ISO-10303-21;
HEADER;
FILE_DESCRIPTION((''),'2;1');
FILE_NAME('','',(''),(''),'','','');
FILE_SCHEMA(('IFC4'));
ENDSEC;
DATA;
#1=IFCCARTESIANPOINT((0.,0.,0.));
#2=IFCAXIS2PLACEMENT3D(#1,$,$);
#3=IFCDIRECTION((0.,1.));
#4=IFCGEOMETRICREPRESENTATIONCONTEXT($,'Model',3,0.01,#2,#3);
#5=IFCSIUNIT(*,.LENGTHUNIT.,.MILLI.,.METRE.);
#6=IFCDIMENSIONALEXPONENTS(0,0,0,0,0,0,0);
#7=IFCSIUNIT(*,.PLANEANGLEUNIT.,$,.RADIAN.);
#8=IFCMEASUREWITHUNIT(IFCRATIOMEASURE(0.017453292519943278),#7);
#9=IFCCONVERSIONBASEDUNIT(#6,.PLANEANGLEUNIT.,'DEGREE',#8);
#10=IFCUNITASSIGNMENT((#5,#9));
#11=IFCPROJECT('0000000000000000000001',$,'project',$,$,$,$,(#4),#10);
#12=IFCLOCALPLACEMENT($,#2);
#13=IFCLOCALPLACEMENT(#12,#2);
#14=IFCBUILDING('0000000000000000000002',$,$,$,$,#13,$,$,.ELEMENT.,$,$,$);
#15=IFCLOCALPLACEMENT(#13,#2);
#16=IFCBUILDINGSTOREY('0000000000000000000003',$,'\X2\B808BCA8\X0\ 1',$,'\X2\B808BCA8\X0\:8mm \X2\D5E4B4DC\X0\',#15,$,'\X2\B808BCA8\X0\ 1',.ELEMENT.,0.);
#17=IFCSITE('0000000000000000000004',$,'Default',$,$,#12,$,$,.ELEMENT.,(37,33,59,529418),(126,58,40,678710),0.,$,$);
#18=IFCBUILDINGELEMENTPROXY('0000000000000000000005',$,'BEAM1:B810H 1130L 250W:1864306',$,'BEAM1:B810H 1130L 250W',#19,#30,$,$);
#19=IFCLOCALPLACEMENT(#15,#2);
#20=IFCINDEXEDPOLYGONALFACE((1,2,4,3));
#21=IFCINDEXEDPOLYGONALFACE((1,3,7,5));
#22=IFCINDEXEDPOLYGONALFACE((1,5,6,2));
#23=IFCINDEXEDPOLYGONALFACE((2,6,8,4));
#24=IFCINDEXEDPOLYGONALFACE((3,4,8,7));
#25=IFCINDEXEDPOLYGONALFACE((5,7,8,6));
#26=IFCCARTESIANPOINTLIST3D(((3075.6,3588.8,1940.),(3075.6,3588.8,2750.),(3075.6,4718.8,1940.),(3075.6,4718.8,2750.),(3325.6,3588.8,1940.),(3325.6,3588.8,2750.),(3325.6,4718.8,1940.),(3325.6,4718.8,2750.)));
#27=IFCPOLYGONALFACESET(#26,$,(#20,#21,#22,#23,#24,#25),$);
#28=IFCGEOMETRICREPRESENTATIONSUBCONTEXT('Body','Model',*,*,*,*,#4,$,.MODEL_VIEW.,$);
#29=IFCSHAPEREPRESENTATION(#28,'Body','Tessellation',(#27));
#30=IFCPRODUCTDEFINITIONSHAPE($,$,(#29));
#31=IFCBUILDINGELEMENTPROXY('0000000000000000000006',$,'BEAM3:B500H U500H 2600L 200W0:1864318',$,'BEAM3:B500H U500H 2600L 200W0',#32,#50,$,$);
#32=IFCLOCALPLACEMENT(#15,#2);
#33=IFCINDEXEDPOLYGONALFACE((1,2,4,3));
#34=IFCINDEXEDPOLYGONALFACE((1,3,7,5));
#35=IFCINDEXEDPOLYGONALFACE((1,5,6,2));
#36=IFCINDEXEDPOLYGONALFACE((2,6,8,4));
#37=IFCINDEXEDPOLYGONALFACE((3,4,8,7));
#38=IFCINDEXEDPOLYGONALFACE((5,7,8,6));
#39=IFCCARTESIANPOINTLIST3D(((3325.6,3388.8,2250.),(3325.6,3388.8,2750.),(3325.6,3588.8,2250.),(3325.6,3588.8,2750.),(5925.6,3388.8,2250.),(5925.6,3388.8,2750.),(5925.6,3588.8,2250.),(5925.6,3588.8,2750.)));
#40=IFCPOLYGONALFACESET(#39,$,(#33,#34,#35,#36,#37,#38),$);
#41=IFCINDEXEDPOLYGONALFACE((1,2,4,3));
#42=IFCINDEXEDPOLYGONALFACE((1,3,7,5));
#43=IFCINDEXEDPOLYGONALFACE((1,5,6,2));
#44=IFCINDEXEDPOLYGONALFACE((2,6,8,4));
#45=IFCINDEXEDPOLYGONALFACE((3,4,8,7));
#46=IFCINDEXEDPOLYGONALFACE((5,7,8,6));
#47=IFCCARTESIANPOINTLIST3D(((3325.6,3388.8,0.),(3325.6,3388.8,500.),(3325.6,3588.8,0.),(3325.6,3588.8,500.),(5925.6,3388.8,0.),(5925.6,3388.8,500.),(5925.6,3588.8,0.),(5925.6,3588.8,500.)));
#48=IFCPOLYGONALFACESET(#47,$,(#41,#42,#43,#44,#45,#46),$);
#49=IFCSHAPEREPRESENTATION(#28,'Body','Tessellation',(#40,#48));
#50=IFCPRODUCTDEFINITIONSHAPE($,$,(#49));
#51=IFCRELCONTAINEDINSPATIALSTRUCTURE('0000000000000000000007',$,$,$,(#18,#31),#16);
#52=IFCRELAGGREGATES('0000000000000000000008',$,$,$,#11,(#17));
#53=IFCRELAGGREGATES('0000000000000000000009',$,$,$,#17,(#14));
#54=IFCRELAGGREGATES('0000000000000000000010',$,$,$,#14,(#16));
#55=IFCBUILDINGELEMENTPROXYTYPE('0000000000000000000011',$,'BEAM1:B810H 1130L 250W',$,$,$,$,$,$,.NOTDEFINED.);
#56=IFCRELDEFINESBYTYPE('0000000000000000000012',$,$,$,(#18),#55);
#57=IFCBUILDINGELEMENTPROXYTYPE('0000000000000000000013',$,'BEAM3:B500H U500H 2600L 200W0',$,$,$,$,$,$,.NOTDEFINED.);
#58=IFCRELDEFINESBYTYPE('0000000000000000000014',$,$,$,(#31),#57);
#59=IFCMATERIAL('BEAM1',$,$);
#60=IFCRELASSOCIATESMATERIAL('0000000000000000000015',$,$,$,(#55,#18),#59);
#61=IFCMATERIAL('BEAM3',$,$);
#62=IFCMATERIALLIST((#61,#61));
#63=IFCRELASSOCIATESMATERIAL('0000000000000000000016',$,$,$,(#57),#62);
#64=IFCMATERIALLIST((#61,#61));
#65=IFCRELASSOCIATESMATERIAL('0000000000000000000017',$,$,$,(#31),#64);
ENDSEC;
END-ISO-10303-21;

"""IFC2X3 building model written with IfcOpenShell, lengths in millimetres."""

from ifc_helpers import new_model, entity, si_unit, converted_unit, direction, frame, origin, origin_2d_with_axis, place, context, subcontext, project, spatial, rectangle, extrude, source, transform, mapped, material, material_list, type_object, type_shapes, element, save


model = new_model("IFC2X3")

# Units and contexts
model_context = context("Model", 3, precision=0.01, world=origin(), true_north=direction((0.0, 1.0)))
body_context = subcontext(model_context, "Body", "Model", "MODEL_VIEW")
ifc_project = project(units=[si_unit("LENGTHUNIT", "METRE", prefix="MILLI"), converted_unit("PLANEANGLEUNIT", "DEGREE", entity("IfcRatioMeasure", 0.017453292519943278), si_unit("PLANEANGLEUNIT", "RADIAN"), dimensions=[0, 0, 0, 0, 0, 0, 0])], contexts=[model_context])

# Site, building, storey
site_placement = place(None, origin())
site = spatial("IfcSite", under=ifc_project, at=site_placement, Name="Default", CompositionType="ELEMENT", RefLatitude=(37, 33, 59, 529418), RefLongitude=(126, 58, 40, 678710), RefElevation=0.0)
building_placement = place(site_placement, origin())
building = spatial("IfcBuilding", under=site, at=building_placement, CompositionType="ELEMENT")
storey_placement = place(building_placement, origin())
storey = spatial("IfcBuildingStorey", under=building, at=storey_placement, Name="레벨 1", ObjectType="레벨:8mm 헤드", LongName="레벨 1", CompositionType="ELEMENT", Elevation=0.0)

# Building element proxies
ifc_material_1 = material(Name="BEAM3")
ifc_material_2 = material(Name="BEAM1")
building_element_proxy_type_1 = type_object("IfcBuildingElementProxyType", Name="BEAM1:B810H 1130L 250W", PredefinedType="NOTDEFINED", material=ifc_material_2)
shared_shape_1 = source(origin(), body_context, "Body", "SweptSolid", [
    extrude(rectangle(XDim=1130.0, YDim=250.0, at=origin_2d_with_axis()), frame((565.0, -125.0, -810.0)), (0.0, 0.0, 1.0), 810.0),
])
type_shapes(building_element_proxy_type_1, [shared_shape_1])
proxy_1_placement = place(storey_placement, frame((3075.6, 3588.8, 2750.0), z_axis=(0.0, 0.0, 1.0), x_axis=(0.0, 1.0, 0.0)))
element("IfcBuildingElementProxy", 1, at=proxy_1_placement, inside=storey, type_object=building_element_proxy_type_1, material=ifc_material_2, Name="BEAM1:B810H 1130L 250W:1864306", ObjectType="BEAM1:B810H 1130L 250W", context=body_context, shape_type="MappedRepresentation", body=[
    mapped(shared_shape_1, transform((0.0, 0.0, 0.0), scale=1.0)),
])
ifc_material_list_1 = material_list([ifc_material_1, ifc_material_1])
ifc_material_list_2 = material_list([ifc_material_1, ifc_material_1])
building_element_proxy_type_2 = type_object("IfcBuildingElementProxyType", Name="BEAM3:B500H U500H 2600L 200W0", PredefinedType="NOTDEFINED", material=ifc_material_list_2)
shared_shape_2 = source(origin(), body_context, "Body", "SweptSolid", [
    extrude(rectangle(XDim=2600.0, YDim=200.0, at=origin_2d_with_axis()), frame((1300.0, -100.0, 2250.0)), (0.0, 0.0, 1.0), 500.0),
    extrude(rectangle(XDim=2600.0, YDim=200.0, at=origin_2d_with_axis()), frame((1300.0, -100.0, 0.0)), (0.0, 0.0, 1.0), 500.0),
])
type_shapes(building_element_proxy_type_2, [shared_shape_2])
proxy_2_placement = place(storey_placement, frame((3325.6, 3588.8, 0.0)))
element("IfcBuildingElementProxy", 2, at=proxy_2_placement, inside=storey, type_object=building_element_proxy_type_2, material=ifc_material_list_1, Name="BEAM3:B500H U500H 2600L 200W0:1864318", ObjectType="BEAM3:B500H U500H 2600L 200W0", context=body_context, shape_type="MappedRepresentation", body=[
    mapped(shared_shape_2, transform((0.0, 0.0, 0.0), scale=1.0)),
])

save(model, "model.ifc")
